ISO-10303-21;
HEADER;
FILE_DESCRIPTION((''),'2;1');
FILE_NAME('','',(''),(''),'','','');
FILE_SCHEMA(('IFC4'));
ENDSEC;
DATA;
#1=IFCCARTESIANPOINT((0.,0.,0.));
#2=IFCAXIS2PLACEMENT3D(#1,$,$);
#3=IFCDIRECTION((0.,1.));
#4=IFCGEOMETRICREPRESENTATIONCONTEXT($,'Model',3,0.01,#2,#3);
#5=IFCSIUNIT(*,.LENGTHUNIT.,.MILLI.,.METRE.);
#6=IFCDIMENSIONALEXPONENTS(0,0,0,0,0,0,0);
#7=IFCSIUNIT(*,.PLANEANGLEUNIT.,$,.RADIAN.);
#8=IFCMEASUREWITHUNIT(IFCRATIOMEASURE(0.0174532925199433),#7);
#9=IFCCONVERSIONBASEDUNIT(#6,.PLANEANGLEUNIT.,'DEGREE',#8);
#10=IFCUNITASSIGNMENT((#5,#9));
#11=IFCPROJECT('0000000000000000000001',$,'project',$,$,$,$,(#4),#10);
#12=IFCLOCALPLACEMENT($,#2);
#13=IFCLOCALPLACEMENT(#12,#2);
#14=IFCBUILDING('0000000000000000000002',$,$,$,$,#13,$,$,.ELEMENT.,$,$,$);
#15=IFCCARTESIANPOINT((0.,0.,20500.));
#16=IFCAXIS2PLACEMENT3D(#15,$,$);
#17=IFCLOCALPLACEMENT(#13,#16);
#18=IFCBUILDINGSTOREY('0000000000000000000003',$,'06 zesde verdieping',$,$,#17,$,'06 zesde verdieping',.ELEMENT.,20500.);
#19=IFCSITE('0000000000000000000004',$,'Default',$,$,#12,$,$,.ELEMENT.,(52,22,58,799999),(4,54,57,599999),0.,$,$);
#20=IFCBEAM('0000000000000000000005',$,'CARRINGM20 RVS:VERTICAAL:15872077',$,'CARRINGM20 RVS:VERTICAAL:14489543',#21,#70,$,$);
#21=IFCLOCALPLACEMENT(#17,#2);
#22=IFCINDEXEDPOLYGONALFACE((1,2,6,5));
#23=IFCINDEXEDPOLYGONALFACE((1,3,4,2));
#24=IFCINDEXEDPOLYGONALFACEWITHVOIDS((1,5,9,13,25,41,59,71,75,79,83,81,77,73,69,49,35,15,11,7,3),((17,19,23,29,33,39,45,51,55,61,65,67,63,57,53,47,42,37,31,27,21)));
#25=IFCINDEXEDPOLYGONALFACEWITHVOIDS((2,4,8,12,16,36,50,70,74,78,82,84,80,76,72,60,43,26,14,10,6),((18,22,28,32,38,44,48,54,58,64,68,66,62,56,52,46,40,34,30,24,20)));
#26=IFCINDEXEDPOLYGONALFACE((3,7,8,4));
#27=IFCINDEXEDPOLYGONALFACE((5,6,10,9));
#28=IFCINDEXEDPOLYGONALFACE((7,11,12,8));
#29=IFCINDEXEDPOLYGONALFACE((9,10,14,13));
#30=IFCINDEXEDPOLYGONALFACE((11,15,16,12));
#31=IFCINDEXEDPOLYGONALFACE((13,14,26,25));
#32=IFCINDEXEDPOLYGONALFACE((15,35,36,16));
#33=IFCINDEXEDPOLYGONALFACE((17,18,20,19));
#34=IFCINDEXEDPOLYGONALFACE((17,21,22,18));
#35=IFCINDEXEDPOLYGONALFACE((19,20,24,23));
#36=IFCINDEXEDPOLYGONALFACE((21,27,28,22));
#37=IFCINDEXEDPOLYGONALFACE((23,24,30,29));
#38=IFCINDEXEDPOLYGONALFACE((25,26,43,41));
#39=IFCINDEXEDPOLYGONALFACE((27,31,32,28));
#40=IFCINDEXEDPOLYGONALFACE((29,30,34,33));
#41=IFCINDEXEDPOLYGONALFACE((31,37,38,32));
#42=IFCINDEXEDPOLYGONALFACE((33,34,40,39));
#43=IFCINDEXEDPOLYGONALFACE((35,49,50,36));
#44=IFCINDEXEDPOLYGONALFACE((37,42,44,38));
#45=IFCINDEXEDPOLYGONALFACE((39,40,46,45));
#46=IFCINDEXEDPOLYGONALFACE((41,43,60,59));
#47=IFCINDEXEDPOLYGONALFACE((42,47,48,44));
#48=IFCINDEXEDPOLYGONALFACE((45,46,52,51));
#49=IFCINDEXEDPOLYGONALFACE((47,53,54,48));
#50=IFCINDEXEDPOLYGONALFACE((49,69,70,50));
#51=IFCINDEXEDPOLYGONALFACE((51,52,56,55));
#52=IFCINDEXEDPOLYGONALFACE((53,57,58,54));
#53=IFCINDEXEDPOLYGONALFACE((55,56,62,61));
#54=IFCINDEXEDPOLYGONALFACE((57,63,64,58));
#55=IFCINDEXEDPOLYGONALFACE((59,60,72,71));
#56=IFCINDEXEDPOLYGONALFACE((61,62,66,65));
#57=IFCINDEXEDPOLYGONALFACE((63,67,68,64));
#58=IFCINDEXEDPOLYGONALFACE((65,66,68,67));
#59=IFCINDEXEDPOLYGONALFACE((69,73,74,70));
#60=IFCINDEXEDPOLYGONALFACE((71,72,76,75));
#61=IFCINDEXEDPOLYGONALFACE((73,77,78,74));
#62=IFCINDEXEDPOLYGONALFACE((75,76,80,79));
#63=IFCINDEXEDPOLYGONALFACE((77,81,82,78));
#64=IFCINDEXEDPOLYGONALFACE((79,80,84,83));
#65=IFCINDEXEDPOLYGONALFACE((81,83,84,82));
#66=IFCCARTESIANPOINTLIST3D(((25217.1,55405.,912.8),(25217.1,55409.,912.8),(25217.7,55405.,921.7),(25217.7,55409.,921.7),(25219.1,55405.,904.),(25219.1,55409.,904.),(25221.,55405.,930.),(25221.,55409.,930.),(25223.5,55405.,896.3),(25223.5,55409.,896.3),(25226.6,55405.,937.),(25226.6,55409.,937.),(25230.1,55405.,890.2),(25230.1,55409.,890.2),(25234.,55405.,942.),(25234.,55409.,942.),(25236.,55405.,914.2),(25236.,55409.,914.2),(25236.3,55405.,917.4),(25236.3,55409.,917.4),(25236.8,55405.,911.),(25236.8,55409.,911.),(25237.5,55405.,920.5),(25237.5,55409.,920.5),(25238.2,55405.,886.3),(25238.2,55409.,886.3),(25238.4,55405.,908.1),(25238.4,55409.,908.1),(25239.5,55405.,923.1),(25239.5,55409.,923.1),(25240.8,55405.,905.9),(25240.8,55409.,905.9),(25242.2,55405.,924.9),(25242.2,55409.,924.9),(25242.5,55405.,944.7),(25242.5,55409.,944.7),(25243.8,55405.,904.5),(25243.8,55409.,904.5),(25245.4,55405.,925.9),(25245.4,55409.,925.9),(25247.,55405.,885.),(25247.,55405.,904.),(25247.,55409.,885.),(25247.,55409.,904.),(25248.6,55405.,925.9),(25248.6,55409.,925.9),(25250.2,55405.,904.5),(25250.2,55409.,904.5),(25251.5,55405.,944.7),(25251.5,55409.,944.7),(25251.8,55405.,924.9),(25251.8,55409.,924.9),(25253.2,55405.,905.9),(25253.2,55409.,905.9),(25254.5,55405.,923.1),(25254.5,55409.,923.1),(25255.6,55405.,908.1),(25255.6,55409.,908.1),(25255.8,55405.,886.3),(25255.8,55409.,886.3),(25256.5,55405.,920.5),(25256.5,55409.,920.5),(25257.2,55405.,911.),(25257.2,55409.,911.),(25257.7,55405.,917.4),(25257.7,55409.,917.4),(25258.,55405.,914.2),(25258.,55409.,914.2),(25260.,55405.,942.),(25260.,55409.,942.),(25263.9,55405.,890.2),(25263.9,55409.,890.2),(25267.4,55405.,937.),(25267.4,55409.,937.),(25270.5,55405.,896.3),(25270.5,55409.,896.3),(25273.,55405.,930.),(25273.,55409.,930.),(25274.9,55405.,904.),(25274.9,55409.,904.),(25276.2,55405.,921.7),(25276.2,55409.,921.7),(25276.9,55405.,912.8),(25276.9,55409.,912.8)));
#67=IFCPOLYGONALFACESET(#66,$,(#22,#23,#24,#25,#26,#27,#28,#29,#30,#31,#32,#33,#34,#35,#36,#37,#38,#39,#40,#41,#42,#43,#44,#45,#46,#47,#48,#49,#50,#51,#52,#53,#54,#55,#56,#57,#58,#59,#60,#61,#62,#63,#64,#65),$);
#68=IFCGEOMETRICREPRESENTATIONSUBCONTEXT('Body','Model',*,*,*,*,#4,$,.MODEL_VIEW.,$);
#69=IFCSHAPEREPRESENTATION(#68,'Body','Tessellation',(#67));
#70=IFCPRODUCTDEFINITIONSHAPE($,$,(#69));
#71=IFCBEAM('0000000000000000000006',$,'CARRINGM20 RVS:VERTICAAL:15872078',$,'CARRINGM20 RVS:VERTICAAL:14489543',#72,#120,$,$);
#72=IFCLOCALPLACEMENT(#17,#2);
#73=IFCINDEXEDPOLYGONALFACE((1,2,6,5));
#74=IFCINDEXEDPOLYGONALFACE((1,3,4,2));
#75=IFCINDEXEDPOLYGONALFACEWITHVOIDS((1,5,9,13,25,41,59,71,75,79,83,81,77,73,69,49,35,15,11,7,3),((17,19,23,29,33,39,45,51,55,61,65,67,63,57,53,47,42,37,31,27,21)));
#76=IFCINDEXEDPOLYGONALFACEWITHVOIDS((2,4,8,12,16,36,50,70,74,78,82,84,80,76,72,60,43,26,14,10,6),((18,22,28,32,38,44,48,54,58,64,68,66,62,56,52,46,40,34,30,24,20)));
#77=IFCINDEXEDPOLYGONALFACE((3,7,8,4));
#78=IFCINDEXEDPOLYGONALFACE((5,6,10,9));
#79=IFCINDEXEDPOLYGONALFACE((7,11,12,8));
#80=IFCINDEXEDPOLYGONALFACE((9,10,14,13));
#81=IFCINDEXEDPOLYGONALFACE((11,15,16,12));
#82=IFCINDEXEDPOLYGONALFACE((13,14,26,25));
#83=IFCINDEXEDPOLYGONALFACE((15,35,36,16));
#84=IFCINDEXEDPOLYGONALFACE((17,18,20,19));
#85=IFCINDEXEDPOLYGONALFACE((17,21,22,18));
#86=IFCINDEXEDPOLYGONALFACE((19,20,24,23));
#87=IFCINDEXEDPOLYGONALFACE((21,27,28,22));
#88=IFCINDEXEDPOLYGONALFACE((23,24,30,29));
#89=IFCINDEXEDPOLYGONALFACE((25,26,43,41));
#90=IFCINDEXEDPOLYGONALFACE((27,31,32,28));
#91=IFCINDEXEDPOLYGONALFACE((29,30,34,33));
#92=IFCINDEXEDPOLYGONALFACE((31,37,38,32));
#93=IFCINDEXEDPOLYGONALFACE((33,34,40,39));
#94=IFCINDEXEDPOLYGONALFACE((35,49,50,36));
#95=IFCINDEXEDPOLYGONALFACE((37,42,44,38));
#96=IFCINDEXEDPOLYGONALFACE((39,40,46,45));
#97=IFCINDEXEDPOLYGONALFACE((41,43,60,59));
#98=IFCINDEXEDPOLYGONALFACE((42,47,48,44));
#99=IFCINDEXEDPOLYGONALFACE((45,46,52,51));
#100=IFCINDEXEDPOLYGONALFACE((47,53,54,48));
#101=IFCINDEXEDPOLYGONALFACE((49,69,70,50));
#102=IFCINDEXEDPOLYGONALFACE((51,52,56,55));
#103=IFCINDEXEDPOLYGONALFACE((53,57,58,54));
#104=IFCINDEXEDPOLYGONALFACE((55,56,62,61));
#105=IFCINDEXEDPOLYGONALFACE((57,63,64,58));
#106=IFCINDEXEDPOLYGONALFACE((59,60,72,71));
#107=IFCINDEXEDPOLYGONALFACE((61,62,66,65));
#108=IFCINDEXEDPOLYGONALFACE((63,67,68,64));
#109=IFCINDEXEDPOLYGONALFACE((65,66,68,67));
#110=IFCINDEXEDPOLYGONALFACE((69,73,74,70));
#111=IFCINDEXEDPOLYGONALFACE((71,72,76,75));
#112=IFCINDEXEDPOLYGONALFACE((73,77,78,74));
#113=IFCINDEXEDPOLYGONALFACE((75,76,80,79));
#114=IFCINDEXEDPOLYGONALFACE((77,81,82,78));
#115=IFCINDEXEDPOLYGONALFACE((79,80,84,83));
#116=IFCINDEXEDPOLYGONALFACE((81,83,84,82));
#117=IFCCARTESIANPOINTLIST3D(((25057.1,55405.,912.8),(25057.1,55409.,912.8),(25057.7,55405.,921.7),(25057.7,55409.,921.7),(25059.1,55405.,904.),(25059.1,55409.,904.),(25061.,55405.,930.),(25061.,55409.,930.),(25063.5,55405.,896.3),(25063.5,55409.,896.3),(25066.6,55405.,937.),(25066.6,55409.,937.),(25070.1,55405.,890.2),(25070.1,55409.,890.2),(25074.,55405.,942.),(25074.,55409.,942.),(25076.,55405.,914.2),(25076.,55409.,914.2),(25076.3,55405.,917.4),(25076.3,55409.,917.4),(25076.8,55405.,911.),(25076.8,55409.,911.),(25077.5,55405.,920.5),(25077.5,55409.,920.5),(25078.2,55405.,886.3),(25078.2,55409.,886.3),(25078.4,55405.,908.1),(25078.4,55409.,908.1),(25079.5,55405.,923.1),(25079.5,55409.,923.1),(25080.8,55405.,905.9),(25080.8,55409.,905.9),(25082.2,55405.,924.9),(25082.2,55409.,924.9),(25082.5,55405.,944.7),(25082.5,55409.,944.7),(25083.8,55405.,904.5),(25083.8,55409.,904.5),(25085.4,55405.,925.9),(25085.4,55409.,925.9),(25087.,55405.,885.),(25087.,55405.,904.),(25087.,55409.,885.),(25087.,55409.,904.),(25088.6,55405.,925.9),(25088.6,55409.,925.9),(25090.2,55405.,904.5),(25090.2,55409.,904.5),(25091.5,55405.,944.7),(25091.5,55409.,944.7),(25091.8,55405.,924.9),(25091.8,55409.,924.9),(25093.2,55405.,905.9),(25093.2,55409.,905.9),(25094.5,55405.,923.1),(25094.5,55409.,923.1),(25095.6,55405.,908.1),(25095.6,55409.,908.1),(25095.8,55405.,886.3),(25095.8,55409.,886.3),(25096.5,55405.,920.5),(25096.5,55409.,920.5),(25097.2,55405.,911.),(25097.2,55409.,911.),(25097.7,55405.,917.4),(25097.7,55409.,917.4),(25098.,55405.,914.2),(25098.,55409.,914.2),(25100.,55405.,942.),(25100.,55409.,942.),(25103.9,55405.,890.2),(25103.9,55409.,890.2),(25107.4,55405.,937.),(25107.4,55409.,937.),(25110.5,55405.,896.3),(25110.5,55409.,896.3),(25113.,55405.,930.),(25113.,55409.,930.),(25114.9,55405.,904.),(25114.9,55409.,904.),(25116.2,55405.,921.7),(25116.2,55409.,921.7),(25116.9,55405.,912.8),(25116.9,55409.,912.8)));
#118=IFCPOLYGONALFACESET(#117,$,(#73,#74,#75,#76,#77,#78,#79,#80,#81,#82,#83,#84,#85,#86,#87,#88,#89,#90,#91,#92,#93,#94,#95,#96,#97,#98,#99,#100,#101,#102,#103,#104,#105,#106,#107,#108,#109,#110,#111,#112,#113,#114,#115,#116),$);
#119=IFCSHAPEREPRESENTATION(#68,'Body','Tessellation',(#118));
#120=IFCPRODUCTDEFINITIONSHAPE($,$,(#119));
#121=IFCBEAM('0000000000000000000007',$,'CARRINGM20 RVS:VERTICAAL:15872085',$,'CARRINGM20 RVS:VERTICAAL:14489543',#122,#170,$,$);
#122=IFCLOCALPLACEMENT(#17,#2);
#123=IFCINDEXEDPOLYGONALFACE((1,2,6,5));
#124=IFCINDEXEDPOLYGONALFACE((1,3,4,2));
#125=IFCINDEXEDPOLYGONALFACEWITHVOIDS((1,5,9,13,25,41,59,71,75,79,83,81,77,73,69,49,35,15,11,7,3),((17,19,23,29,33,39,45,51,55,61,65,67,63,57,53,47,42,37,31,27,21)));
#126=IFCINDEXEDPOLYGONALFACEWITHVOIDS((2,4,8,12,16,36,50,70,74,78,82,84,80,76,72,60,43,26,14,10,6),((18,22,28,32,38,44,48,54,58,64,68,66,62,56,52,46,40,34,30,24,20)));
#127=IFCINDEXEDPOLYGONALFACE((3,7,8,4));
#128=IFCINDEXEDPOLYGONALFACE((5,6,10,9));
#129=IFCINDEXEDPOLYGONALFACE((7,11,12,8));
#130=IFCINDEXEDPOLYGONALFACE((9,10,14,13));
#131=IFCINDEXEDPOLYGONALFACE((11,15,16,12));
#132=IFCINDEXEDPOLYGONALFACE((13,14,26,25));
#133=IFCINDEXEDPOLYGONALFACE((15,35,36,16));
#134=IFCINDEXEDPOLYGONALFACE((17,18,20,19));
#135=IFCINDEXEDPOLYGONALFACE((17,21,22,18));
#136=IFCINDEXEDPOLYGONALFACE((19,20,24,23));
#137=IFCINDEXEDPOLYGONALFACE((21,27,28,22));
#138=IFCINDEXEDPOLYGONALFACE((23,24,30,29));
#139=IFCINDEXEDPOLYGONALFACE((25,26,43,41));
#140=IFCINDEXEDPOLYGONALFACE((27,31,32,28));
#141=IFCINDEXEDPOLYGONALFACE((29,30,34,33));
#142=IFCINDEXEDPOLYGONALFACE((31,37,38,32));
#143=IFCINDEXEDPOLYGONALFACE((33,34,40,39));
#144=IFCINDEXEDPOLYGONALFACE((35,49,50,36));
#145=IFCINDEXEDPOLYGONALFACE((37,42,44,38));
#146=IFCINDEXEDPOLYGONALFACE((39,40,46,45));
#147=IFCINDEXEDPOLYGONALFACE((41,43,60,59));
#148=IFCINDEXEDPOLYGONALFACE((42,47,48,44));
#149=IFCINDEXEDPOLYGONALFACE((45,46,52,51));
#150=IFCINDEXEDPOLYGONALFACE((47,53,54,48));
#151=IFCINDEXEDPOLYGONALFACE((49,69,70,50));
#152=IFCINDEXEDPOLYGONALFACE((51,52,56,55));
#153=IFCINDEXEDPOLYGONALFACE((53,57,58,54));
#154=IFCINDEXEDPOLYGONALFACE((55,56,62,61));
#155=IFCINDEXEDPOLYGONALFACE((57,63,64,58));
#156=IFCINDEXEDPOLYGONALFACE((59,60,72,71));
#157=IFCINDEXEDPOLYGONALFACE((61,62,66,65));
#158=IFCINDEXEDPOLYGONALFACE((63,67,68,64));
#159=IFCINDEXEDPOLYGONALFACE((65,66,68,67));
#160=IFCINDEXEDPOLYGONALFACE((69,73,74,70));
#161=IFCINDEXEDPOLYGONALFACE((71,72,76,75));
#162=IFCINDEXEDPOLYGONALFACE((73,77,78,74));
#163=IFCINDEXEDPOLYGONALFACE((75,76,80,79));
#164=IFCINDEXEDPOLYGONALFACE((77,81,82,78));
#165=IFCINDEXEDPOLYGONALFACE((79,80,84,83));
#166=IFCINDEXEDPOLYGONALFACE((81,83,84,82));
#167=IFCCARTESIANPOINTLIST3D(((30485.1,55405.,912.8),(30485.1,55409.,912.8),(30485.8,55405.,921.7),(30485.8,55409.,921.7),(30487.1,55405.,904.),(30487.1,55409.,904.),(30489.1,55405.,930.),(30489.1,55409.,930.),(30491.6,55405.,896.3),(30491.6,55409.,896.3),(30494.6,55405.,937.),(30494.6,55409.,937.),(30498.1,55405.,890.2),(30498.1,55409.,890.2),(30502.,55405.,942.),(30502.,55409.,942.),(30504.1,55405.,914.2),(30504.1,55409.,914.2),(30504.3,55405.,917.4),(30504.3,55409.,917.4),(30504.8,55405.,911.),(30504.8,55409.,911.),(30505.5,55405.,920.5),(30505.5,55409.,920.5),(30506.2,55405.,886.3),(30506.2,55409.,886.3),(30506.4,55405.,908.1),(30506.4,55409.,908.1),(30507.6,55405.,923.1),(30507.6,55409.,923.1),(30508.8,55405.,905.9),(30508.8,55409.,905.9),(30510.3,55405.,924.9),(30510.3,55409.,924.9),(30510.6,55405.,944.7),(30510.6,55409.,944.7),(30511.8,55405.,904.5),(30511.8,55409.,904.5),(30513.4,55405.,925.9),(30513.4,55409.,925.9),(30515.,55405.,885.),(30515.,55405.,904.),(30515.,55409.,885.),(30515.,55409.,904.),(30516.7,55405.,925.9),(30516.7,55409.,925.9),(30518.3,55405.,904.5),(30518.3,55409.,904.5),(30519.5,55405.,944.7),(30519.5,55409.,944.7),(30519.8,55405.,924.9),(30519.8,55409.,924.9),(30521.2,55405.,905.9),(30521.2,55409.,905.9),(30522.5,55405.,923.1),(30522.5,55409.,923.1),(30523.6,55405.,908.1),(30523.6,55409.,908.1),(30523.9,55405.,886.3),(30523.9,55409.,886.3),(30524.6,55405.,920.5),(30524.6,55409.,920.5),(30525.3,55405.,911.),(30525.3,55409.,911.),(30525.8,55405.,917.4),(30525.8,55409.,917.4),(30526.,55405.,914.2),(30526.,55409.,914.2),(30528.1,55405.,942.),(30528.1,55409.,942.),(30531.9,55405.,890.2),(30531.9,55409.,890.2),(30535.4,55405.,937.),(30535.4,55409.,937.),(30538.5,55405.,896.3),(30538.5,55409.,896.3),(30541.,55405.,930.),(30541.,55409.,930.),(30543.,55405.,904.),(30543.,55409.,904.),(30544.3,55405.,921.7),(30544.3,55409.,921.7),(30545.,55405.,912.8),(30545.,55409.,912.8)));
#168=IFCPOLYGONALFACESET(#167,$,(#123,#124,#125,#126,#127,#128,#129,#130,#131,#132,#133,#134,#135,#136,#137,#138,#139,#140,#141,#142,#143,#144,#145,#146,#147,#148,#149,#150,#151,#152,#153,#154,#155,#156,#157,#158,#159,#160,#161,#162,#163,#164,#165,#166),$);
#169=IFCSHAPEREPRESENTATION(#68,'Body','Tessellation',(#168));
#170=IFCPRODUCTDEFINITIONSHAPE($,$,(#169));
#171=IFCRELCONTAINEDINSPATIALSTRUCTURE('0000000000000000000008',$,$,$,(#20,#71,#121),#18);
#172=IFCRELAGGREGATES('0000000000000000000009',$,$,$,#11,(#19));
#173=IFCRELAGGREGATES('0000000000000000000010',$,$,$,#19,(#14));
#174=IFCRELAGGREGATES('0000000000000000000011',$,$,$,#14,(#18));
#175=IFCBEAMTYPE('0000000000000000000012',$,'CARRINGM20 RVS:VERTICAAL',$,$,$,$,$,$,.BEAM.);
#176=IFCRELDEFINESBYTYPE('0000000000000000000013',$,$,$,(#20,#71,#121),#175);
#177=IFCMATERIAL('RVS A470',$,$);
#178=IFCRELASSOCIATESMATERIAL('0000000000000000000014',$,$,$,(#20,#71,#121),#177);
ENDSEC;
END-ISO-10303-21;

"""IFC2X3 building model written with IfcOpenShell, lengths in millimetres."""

from ifc_helpers import new_model, entity, si_unit, converted_unit, direction, frame, origin, origin_2d_with_axis, place, context, subcontext, project, spatial, hollow_circle, extrude, material, type_object, element, save


model = new_model("IFC2X3")

# Units and contexts
model_context = context("Model", 3, precision=0.01, world=origin(), true_north=direction((0.0, 1.0)))
body_context = subcontext(model_context, "Body", "Model", "MODEL_VIEW")
ifc_project = project(units=[si_unit("LENGTHUNIT", "METRE", prefix="MILLI"), converted_unit("PLANEANGLEUNIT", "DEGREE", entity("IfcRatioMeasure", 0.0174532925199433), si_unit("PLANEANGLEUNIT", "RADIAN"), dimensions=[0, 0, 0, 0, 0, 0, 0])], contexts=[model_context])

# Site, building, storey
site_placement = place(None, origin())
site = spatial("IfcSite", under=ifc_project, at=site_placement, Name="Default", CompositionType="ELEMENT", RefLatitude=(52, 22, 58, 799999), RefLongitude=(4, 54, 57, 599999), RefElevation=0.0)
building_placement = place(site_placement, origin())
building = spatial("IfcBuilding", under=site, at=building_placement, CompositionType="ELEMENT")
storey_placement = place(building_placement, frame((0.0, 0.0, 20500.0)))
storey = spatial("IfcBuildingStorey", under=building, at=storey_placement, Name="06 zesde verdieping", LongName="06 zesde verdieping", CompositionType="ELEMENT", Elevation=20500.0)

# Beams
ifc_material_1 = material(Name="RVS A470")
beam_type_1 = type_object("IfcBeamType", Name="CARRINGM20 RVS:VERTICAAL", PredefinedType="BEAM")
beam_1_placement = place(storey_placement, origin())
element("IfcBeam", 1, at=beam_1_placement, inside=storey, type_object=beam_type_1, material=ifc_material_1, Name="CARRINGM20 RVS:VERTICAAL:15872077", ObjectType="CARRINGM20 RVS:VERTICAAL:14489543", context=body_context, shape_type="SweptSolid", body=[
    extrude(hollow_circle(Radius=30.0, WallThickness=19.0, at=origin_2d_with_axis()), frame((25247.0, 55405.0, 915.0), z_axis=(0.0, 1.0, 0.0), x_axis=(0.0, 0.0, -1.0)), (0.0, 0.0, 1.0), 4.0),
])
beam_2_placement = place(storey_placement, origin())
element("IfcBeam", 2, at=beam_2_placement, inside=storey, type_object=beam_type_1, material=ifc_material_1, Name="CARRINGM20 RVS:VERTICAAL:15872078", ObjectType="CARRINGM20 RVS:VERTICAAL:14489543", context=body_context, shape_type="SweptSolid", body=[
    extrude(hollow_circle(Radius=30.0, WallThickness=19.0, at=origin_2d_with_axis()), frame((25087.0, 55405.0, 915.0), z_axis=(0.0, 1.0, 0.0), x_axis=(0.0, 0.0, -1.0)), (0.0, 0.0, 1.0), 4.0),
])
beam_3_placement = place(storey_placement, origin())
element("IfcBeam", 3, at=beam_3_placement, inside=storey, type_object=beam_type_1, material=ifc_material_1, Name="CARRINGM20 RVS:VERTICAAL:15872085", ObjectType="CARRINGM20 RVS:VERTICAAL:14489543", context=body_context, shape_type="SweptSolid", body=[
    extrude(hollow_circle(Radius=30.0, WallThickness=19.0, at=origin_2d_with_axis()), frame((30515.0, 55405.0, 915.0), z_axis=(0.0, 1.0, 0.0), x_axis=(0.0, 0.0, -1.0)), (0.0, 0.0, 1.0), 4.0),
])

save(model, "model.ifc")
